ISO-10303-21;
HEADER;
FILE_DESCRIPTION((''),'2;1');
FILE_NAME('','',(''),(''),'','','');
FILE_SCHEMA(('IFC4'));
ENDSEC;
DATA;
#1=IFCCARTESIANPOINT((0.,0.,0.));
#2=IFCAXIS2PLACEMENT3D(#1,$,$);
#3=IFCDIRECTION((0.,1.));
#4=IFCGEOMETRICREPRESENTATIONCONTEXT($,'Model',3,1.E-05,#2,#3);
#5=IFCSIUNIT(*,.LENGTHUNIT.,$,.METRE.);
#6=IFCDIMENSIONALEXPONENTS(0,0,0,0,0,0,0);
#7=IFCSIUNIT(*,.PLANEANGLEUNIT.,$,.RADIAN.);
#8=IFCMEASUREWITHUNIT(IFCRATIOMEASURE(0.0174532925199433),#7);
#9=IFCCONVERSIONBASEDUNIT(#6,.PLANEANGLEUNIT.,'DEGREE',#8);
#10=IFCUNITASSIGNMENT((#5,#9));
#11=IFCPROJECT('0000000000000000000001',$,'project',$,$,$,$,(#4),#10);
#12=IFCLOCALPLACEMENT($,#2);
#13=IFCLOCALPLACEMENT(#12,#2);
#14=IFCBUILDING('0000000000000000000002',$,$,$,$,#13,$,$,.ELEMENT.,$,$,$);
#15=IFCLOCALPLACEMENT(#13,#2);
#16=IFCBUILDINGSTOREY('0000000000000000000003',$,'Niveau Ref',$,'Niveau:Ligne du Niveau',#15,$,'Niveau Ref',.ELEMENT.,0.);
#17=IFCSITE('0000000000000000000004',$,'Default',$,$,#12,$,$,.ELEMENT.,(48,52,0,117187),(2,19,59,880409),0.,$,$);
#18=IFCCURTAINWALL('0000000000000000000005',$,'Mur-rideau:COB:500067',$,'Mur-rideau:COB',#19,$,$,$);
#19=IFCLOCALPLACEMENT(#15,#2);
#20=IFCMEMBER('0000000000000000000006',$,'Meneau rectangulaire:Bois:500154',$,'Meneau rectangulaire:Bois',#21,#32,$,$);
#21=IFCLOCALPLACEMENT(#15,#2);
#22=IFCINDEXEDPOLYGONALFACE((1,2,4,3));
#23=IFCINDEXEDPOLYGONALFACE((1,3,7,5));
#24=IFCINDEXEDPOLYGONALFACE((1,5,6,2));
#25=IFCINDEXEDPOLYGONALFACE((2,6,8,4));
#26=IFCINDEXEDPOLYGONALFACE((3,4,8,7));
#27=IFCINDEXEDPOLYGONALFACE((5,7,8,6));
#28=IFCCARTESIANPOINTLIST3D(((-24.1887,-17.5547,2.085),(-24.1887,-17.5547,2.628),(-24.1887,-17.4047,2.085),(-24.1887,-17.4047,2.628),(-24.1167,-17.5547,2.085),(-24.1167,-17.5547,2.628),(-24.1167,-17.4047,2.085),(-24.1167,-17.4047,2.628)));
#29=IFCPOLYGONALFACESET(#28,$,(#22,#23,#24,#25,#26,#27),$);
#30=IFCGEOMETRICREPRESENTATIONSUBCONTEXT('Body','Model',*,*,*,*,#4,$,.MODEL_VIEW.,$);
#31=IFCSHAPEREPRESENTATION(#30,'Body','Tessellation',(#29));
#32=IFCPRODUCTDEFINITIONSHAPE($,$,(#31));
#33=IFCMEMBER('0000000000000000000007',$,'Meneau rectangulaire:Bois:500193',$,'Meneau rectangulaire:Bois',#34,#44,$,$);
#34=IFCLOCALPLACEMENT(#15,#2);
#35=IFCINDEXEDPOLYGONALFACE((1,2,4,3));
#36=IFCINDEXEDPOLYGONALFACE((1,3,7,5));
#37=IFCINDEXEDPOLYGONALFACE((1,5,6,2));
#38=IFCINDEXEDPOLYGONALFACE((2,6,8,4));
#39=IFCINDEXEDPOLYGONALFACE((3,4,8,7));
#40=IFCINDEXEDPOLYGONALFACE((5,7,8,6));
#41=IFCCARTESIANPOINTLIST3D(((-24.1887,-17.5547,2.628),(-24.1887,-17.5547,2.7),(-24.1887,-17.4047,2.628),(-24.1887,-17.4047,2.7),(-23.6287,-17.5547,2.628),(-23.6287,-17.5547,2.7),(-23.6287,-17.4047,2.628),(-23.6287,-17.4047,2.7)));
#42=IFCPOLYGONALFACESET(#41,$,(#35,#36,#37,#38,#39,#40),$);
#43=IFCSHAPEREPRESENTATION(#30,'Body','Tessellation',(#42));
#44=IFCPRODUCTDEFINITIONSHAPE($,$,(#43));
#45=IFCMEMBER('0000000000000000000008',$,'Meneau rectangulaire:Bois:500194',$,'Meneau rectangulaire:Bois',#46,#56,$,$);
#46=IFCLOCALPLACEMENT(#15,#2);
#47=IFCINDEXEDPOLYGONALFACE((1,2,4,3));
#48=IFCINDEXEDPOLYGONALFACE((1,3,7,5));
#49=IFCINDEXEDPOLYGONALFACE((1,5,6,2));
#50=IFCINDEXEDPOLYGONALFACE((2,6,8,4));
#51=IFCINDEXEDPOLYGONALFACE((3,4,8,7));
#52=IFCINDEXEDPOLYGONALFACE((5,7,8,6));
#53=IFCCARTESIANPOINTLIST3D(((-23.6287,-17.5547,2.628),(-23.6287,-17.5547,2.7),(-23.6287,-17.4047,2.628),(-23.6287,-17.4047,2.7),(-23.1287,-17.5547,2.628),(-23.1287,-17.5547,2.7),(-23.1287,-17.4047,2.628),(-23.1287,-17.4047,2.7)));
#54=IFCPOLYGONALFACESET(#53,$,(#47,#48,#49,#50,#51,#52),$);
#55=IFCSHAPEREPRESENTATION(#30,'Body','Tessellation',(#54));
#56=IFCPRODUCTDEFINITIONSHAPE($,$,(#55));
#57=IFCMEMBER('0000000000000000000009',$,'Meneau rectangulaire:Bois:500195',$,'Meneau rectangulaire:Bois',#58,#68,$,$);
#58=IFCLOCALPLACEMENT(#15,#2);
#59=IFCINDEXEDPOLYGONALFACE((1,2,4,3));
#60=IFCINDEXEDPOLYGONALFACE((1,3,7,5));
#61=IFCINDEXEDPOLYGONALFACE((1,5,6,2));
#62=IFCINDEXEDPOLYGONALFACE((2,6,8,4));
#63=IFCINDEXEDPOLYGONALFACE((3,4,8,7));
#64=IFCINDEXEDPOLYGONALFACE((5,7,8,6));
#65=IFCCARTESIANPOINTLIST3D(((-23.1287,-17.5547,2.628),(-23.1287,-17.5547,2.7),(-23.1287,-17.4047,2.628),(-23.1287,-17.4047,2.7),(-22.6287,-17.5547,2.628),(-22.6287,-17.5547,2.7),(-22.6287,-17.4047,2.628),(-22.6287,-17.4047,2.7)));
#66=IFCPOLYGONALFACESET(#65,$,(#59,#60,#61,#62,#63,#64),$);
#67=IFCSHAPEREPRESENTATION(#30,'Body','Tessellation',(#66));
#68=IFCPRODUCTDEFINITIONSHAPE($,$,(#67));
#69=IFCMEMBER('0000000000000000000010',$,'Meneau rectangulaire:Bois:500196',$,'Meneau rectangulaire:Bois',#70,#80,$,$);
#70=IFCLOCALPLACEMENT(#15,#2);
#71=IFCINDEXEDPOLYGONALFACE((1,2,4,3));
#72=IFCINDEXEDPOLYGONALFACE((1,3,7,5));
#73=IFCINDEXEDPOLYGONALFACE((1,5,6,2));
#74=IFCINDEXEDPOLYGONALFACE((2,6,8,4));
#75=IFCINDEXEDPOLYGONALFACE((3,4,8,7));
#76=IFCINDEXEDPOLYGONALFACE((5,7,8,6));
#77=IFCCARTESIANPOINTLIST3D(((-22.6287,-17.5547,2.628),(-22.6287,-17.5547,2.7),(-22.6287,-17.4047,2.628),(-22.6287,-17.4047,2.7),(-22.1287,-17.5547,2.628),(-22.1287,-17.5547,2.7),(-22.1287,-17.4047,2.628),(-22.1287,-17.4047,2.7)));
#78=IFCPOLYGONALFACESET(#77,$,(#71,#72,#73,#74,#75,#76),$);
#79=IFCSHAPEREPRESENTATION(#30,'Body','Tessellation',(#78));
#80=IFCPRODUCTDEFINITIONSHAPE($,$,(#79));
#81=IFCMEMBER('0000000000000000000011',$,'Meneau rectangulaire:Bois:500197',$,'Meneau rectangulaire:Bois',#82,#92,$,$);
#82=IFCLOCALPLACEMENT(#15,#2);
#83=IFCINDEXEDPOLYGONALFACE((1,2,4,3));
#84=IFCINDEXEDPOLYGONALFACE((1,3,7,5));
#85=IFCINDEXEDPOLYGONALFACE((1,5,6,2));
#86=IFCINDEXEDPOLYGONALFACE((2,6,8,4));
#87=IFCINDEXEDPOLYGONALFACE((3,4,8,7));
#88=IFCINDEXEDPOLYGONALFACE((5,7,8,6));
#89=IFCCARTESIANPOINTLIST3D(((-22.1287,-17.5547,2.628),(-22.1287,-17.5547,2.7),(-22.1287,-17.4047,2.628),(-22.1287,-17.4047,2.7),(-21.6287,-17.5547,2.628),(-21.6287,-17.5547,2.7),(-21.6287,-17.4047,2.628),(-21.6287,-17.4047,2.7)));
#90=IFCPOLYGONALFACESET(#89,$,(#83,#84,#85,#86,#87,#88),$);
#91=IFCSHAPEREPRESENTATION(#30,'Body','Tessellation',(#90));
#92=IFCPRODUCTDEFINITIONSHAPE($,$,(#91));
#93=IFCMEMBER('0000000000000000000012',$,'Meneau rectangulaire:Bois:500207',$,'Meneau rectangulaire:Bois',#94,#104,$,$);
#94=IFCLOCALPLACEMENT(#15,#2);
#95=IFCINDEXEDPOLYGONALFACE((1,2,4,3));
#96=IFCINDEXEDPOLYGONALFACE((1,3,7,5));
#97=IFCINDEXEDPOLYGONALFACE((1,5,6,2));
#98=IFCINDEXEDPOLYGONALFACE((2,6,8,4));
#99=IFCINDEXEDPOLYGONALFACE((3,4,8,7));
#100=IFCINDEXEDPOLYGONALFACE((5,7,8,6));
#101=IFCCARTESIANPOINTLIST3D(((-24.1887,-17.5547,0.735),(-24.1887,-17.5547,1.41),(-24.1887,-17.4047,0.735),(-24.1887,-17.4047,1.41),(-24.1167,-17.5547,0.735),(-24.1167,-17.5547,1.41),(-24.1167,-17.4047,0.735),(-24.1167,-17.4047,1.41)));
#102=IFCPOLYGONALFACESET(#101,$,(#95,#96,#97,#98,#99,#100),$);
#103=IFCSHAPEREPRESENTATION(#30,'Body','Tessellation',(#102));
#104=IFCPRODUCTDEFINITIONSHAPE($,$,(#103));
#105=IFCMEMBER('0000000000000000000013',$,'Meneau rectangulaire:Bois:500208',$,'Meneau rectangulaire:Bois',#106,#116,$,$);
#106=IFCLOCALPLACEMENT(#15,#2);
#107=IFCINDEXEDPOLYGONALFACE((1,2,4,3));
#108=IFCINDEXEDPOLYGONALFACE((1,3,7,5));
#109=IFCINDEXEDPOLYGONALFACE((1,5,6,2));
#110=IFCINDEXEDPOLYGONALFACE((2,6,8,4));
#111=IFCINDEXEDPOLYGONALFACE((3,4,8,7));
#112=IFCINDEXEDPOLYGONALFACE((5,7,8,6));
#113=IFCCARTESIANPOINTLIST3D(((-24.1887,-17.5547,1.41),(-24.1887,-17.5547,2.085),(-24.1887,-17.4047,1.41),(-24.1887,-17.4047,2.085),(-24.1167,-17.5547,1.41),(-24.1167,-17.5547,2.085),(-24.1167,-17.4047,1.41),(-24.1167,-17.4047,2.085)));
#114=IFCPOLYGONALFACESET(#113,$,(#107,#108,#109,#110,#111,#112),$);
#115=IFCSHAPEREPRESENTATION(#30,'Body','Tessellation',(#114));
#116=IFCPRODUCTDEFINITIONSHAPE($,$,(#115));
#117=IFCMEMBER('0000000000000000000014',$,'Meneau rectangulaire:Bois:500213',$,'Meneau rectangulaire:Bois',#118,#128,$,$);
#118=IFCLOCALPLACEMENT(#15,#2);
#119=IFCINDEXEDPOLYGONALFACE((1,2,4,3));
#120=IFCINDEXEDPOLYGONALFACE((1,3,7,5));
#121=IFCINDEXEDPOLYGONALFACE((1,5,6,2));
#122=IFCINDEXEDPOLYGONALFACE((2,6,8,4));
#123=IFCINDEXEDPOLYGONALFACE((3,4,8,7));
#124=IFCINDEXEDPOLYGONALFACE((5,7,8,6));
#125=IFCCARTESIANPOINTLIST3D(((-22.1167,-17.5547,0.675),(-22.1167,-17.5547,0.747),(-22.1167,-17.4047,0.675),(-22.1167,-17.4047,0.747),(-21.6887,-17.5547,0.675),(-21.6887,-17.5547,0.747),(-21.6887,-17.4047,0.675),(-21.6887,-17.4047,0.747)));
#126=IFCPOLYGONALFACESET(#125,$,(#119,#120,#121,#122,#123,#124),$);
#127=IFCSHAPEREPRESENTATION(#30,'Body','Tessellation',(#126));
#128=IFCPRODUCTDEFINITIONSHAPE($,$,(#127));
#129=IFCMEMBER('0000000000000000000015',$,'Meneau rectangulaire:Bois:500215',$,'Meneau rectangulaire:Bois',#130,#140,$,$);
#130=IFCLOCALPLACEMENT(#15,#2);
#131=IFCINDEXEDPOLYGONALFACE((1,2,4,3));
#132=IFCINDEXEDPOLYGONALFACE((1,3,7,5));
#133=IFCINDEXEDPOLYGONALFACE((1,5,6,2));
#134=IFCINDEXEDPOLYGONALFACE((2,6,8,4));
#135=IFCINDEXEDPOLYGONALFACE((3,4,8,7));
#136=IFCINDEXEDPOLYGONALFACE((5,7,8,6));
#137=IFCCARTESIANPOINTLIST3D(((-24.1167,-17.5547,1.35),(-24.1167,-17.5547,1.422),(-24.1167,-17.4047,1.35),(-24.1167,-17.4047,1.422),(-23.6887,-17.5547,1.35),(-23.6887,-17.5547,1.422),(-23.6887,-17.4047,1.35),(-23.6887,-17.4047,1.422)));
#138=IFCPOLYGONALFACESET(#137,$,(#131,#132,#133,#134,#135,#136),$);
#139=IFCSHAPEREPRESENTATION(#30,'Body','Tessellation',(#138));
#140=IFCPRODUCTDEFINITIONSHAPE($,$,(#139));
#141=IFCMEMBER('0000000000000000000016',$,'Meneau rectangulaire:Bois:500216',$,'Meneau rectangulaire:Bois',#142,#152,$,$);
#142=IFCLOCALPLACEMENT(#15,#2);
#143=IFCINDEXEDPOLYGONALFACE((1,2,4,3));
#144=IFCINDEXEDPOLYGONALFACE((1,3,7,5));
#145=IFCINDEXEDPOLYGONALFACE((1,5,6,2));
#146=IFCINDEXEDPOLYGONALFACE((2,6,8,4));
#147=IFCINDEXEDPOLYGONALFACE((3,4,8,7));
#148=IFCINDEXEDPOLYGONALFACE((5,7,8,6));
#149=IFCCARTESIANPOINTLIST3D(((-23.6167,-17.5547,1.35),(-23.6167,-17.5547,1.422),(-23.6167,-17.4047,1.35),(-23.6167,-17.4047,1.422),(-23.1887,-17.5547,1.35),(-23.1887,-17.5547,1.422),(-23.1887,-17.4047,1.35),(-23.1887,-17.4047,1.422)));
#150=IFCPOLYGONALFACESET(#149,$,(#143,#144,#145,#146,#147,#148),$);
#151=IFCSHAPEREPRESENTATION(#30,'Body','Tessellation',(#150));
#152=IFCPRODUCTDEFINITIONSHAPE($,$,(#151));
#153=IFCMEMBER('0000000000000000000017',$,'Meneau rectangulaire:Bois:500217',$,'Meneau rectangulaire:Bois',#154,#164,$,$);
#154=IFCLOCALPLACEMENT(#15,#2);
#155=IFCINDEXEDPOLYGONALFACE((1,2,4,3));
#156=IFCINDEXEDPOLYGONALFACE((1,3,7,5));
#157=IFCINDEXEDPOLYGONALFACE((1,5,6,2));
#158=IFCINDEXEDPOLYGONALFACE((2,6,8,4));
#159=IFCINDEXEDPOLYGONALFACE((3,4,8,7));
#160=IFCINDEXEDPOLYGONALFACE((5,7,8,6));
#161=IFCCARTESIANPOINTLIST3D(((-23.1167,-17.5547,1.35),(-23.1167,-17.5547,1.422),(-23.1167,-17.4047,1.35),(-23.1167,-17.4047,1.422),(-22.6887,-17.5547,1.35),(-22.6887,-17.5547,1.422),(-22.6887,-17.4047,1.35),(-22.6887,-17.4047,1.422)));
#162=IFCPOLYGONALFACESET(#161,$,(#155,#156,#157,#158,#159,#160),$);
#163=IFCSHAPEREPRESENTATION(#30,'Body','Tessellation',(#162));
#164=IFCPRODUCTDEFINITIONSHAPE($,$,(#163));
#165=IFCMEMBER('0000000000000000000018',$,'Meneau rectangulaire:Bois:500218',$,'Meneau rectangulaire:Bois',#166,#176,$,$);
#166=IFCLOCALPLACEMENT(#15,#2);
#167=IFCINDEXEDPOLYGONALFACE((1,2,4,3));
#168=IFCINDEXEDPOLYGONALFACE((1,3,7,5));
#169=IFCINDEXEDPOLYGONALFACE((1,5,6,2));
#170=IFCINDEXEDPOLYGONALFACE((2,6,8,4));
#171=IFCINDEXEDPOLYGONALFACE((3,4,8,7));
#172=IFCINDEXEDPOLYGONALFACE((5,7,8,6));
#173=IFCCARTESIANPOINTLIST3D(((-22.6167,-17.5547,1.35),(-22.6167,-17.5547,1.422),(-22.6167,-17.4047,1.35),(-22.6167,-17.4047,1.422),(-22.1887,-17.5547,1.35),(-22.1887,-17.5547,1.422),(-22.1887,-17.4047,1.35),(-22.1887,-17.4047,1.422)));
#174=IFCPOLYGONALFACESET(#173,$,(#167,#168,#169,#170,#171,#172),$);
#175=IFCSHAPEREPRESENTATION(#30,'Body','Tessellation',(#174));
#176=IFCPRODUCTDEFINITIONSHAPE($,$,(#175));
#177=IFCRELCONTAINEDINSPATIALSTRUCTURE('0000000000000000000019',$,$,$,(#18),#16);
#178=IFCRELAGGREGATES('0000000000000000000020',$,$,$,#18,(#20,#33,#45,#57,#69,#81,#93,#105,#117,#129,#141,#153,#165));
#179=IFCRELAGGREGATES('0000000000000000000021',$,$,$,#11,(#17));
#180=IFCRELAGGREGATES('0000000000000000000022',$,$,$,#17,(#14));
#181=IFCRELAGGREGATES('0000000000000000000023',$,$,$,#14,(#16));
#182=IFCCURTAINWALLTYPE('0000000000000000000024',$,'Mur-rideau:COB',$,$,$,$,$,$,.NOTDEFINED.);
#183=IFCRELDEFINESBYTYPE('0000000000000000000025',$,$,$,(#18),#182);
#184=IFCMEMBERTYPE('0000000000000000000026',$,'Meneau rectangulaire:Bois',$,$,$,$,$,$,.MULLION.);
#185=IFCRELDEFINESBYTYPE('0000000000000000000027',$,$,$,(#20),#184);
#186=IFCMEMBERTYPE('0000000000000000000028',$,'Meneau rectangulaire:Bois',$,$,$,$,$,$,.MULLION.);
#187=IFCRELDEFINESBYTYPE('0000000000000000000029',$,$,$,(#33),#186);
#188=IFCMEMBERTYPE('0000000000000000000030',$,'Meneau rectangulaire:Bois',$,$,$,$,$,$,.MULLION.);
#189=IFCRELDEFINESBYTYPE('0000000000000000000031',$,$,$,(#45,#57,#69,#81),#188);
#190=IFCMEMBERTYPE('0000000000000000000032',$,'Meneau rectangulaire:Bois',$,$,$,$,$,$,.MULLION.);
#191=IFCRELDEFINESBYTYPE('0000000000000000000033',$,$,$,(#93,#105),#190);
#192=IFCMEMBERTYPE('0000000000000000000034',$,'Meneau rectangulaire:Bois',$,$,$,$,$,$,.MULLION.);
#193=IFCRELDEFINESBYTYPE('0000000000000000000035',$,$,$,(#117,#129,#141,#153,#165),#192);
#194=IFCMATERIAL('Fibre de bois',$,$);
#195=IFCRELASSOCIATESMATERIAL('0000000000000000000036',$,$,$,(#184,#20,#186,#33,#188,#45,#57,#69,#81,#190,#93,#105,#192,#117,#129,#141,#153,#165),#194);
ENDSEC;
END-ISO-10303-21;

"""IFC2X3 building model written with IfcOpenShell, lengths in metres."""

from ifc_helpers import new_model, entity, si_unit, converted_unit, direction, frame, origin, origin_2d_with_axis, place, context, subcontext, project, spatial, rectangle, extrude, source, transform, mapped, material, type_object, type_shapes, element, aggregate, save


model = new_model("IFC2X3")

# Units and contexts
model_context = context("Model", 3, precision=1e-05, world=origin(), true_north=direction((0.0, 1.0)))
body_context = subcontext(model_context, "Body", "Model", "MODEL_VIEW")
ifc_project = project(units=[si_unit("LENGTHUNIT", "METRE"), converted_unit("PLANEANGLEUNIT", "DEGREE", entity("IfcRatioMeasure", 0.0174532925199433), si_unit("PLANEANGLEUNIT", "RADIAN"), dimensions=[0, 0, 0, 0, 0, 0, 0])], contexts=[model_context])

# Site, building, storey
site_placement = place(None, origin())
site = spatial("IfcSite", under=ifc_project, at=site_placement, Name="Default", CompositionType="ELEMENT", RefLatitude=(48, 52, 0, 117187), RefLongitude=(2, 19, 59, 880409), RefElevation=0.0)
building_placement = place(site_placement, origin())
building = spatial("IfcBuilding", under=site, at=building_placement, CompositionType="ELEMENT")
storey_placement = place(building_placement, origin())
storey = spatial("IfcBuildingStorey", under=building, at=storey_placement, Name="Niveau Ref", ObjectType="Niveau:Ligne du Niveau", LongName="Niveau Ref", CompositionType="ELEMENT", Elevation=0.0)

# Curtain wall, members
curtain_wall_type = type_object("IfcCurtainWallType", Name="Mur-rideau:COB", PredefinedType="NOTDEFINED")
curtain_wall_placement = place(storey_placement, origin())
curtain_wall = element("IfcCurtainWall", 1, at=curtain_wall_placement, inside=storey, type_object=curtain_wall_type, Name="Mur-rideau:COB:500067", ObjectType="Mur-rideau:COB")
ifc_material = material(Name="Fibre de bois")
member_type_1 = type_object("IfcMemberType", Name="Meneau rectangulaire:Bois", PredefinedType="MULLION", material=ifc_material)
shared_shape_1 = source(origin(), body_context, "Body", "SweptSolid", [
    extrude(rectangle(XDim=0.15, YDim=0.072, at=origin_2d_with_axis()), frame((-0.036, 0.0, -0.543), z_axis=(0.0, 0.0, 1.0), x_axis=(0.0, -1.0, 0.0)), (0.0, 0.0, 1.0), 0.543),
])
type_shapes(member_type_1, [shared_shape_1])
member_1_placement = place(storey_placement, frame((-24.1887, -17.4797, 2.628), z_axis=(0.0, 0.0, 1.0), x_axis=(-1.0, 0.0, 0.0)))
member_1 = element("IfcMember", 2, at=member_1_placement, type_object=member_type_1, material=ifc_material, Name="Meneau rectangulaire:Bois:500154", ObjectType="Meneau rectangulaire:Bois", context=body_context, shape_type="MappedRepresentation", body=[
    mapped(shared_shape_1, transform((0.0, 0.0, 0.0), scale=1.0)),
])
member_type_2 = type_object("IfcMemberType", Name="Meneau rectangulaire:Bois", PredefinedType="MULLION", material=ifc_material)
shared_shape_2 = source(origin(), body_context, "Body", "SweptSolid", [
    extrude(rectangle(XDim=0.15, YDim=0.072, at=origin_2d_with_axis()), frame((-0.036, 0.0, -0.56), z_axis=(0.0, 0.0, 1.0), x_axis=(0.0, -1.0, 0.0)), (0.0, 0.0, 1.0), 0.56),
])
type_shapes(member_type_2, [shared_shape_2])
member_2_placement = place(storey_placement, frame((-23.6287, -17.4797, 2.7), z_axis=(1.0, 0.0, 0.0), x_axis=(0.0, 0.0, 1.0)))
member_2 = element("IfcMember", 3, at=member_2_placement, type_object=member_type_2, material=ifc_material, Name="Meneau rectangulaire:Bois:500193", ObjectType="Meneau rectangulaire:Bois", context=body_context, shape_type="MappedRepresentation", body=[
    mapped(shared_shape_2, transform((0.0, 0.0, 0.0), scale=1.0)),
])
member_type_3 = type_object("IfcMemberType", Name="Meneau rectangulaire:Bois", PredefinedType="MULLION", material=ifc_material)
shared_shape_3 = source(origin(), body_context, "Body", "SweptSolid", [
    extrude(rectangle(XDim=0.15, YDim=0.072, at=origin_2d_with_axis()), frame((-0.036, 0.0, -0.5), z_axis=(0.0, 0.0, 1.0), x_axis=(0.0, -1.0, 0.0)), (0.0, 0.0, 1.0), 0.5),
])
type_shapes(member_type_3, [shared_shape_3])
member_3_placement = place(storey_placement, frame((-23.1287, -17.4797, 2.7), z_axis=(1.0, 0.0, 0.0), x_axis=(0.0, 0.0, 1.0)))
member_3 = element("IfcMember", 4, at=member_3_placement, type_object=member_type_3, material=ifc_material, Name="Meneau rectangulaire:Bois:500194", ObjectType="Meneau rectangulaire:Bois", context=body_context, shape_type="MappedRepresentation", body=[
    mapped(shared_shape_3, transform((0.0, 0.0, 0.0), scale=1.0)),
])
member_4_placement = place(storey_placement, frame((-22.6287, -17.4797, 2.7), z_axis=(1.0, 0.0, 0.0), x_axis=(0.0, 0.0, 1.0)))
member_4 = element("IfcMember", 5, at=member_4_placement, type_object=member_type_3, material=ifc_material, Name="Meneau rectangulaire:Bois:500195", ObjectType="Meneau rectangulaire:Bois", context=body_context, shape_type="MappedRepresentation", body=[
    mapped(shared_shape_3, transform((0.0, 0.0, 0.0), scale=1.0)),
])
member_5_placement = place(storey_placement, frame((-22.1287, -17.4797, 2.7), z_axis=(1.0, 0.0, 0.0), x_axis=(0.0, 0.0, 1.0)))
member_5 = element("IfcMember", 6, at=member_5_placement, type_object=member_type_3, material=ifc_material, Name="Meneau rectangulaire:Bois:500196", ObjectType="Meneau rectangulaire:Bois", context=body_context, shape_type="MappedRepresentation", body=[
    mapped(shared_shape_3, transform((0.0, 0.0, 0.0), scale=1.0)),
])
member_6_placement = place(storey_placement, frame((-21.6287, -17.4797, 2.7), z_axis=(1.0, 0.0, 0.0), x_axis=(0.0, 0.0, 1.0)))
member_6 = element("IfcMember", 7, at=member_6_placement, type_object=member_type_3, material=ifc_material, Name="Meneau rectangulaire:Bois:500197", ObjectType="Meneau rectangulaire:Bois", context=body_context, shape_type="MappedRepresentation", body=[
    mapped(shared_shape_3, transform((0.0, 0.0, 0.0), scale=1.0)),
])
member_type_4 = type_object("IfcMemberType", Name="Meneau rectangulaire:Bois", PredefinedType="MULLION", material=ifc_material)
shared_shape_4 = source(origin(), body_context, "Body", "SweptSolid", [
    extrude(rectangle(XDim=0.15, YDim=0.072, at=origin_2d_with_axis()), frame((-0.036, 0.0, -0.675), z_axis=(0.0, 0.0, 1.0), x_axis=(0.0, -1.0, 0.0)), (0.0, 0.0, 1.0), 0.675),
])
type_shapes(member_type_4, [shared_shape_4])
member_7_placement = place(storey_placement, frame((-24.1887, -17.4797, 1.41), z_axis=(0.0, 0.0, 1.0), x_axis=(-1.0, 0.0, 0.0)))
member_7 = element("IfcMember", 8, at=member_7_placement, type_object=member_type_4, material=ifc_material, Name="Meneau rectangulaire:Bois:500207", ObjectType="Meneau rectangulaire:Bois", context=body_context, shape_type="MappedRepresentation", body=[
    mapped(shared_shape_4, transform((0.0, 0.0, 0.0), scale=1.0)),
])
member_8_placement = place(storey_placement, frame((-24.1887, -17.4797, 2.085), z_axis=(0.0, 0.0, 1.0), x_axis=(-1.0, 0.0, 0.0)))
member_8 = element("IfcMember", 9, at=member_8_placement, type_object=member_type_4, material=ifc_material, Name="Meneau rectangulaire:Bois:500208", ObjectType="Meneau rectangulaire:Bois", context=body_context, shape_type="MappedRepresentation", body=[
    mapped(shared_shape_4, transform((0.0, 0.0, 0.0), scale=1.0)),
])
member_type_5 = type_object("IfcMemberType", Name="Meneau rectangulaire:Bois", PredefinedType="MULLION", material=ifc_material)
shared_shape_5 = source(origin(), body_context, "Body", "SweptSolid", [
    extrude(rectangle(XDim=0.15, YDim=0.072, at=origin_2d_with_axis()), frame((-0.024, 0.0, -0.428), z_axis=(0.0, 0.0, 1.0), x_axis=(0.0, -1.0, 0.0)), (0.0, 0.0, 1.0), 0.428),
])
type_shapes(member_type_5, [shared_shape_5])
member_9_placement = place(storey_placement, frame((-21.6887, -17.4797, 0.735), z_axis=(1.0, 0.0, 0.0), x_axis=(0.0, 0.0, 1.0)))
member_9 = element("IfcMember", 10, at=member_9_placement, type_object=member_type_5, material=ifc_material, Name="Meneau rectangulaire:Bois:500213", ObjectType="Meneau rectangulaire:Bois", context=body_context, shape_type="MappedRepresentation", body=[
    mapped(shared_shape_5, transform((0.0, 0.0, 0.0), scale=1.0)),
])
member_10_placement = place(storey_placement, frame((-23.6887, -17.4797, 1.41), z_axis=(1.0, 0.0, 0.0), x_axis=(0.0, 0.0, 1.0)))
member_10 = element("IfcMember", 11, at=member_10_placement, type_object=member_type_5, material=ifc_material, Name="Meneau rectangulaire:Bois:500215", ObjectType="Meneau rectangulaire:Bois", context=body_context, shape_type="MappedRepresentation", body=[
    mapped(shared_shape_5, transform((0.0, 0.0, 0.0), scale=1.0)),
])
member_11_placement = place(storey_placement, frame((-23.1887, -17.4797, 1.41), z_axis=(1.0, 0.0, 0.0), x_axis=(0.0, 0.0, 1.0)))
member_11 = element("IfcMember", 12, at=member_11_placement, type_object=member_type_5, material=ifc_material, Name="Meneau rectangulaire:Bois:500216", ObjectType="Meneau rectangulaire:Bois", context=body_context, shape_type="MappedRepresentation", body=[
    mapped(shared_shape_5, transform((0.0, 0.0, 0.0), scale=1.0)),
])
member_12_placement = place(storey_placement, frame((-22.6887, -17.4797, 1.41), z_axis=(1.0, 0.0, 0.0), x_axis=(0.0, 0.0, 1.0)))
member_12 = element("IfcMember", 13, at=member_12_placement, type_object=member_type_5, material=ifc_material, Name="Meneau rectangulaire:Bois:500217", ObjectType="Meneau rectangulaire:Bois", context=body_context, shape_type="MappedRepresentation", body=[
    mapped(shared_shape_5, transform((0.0, 0.0, 0.0), scale=1.0)),
])
member_13_placement = place(storey_placement, frame((-22.1887, -17.4797, 1.41), z_axis=(1.0, 0.0, 0.0), x_axis=(0.0, 0.0, 1.0)))
member_13 = element("IfcMember", 14, at=member_13_placement, type_object=member_type_5, material=ifc_material, Name="Meneau rectangulaire:Bois:500218", ObjectType="Meneau rectangulaire:Bois", context=body_context, shape_type="MappedRepresentation", body=[
    mapped(shared_shape_5, transform((0.0, 0.0, 0.0), scale=1.0)),
])
aggregate(curtain_wall, [member_1, member_2, member_3, member_4, member_5, member_6, member_7, member_8, member_9, member_10, member_11, member_12, member_13])

save(model, "model.ifc")
